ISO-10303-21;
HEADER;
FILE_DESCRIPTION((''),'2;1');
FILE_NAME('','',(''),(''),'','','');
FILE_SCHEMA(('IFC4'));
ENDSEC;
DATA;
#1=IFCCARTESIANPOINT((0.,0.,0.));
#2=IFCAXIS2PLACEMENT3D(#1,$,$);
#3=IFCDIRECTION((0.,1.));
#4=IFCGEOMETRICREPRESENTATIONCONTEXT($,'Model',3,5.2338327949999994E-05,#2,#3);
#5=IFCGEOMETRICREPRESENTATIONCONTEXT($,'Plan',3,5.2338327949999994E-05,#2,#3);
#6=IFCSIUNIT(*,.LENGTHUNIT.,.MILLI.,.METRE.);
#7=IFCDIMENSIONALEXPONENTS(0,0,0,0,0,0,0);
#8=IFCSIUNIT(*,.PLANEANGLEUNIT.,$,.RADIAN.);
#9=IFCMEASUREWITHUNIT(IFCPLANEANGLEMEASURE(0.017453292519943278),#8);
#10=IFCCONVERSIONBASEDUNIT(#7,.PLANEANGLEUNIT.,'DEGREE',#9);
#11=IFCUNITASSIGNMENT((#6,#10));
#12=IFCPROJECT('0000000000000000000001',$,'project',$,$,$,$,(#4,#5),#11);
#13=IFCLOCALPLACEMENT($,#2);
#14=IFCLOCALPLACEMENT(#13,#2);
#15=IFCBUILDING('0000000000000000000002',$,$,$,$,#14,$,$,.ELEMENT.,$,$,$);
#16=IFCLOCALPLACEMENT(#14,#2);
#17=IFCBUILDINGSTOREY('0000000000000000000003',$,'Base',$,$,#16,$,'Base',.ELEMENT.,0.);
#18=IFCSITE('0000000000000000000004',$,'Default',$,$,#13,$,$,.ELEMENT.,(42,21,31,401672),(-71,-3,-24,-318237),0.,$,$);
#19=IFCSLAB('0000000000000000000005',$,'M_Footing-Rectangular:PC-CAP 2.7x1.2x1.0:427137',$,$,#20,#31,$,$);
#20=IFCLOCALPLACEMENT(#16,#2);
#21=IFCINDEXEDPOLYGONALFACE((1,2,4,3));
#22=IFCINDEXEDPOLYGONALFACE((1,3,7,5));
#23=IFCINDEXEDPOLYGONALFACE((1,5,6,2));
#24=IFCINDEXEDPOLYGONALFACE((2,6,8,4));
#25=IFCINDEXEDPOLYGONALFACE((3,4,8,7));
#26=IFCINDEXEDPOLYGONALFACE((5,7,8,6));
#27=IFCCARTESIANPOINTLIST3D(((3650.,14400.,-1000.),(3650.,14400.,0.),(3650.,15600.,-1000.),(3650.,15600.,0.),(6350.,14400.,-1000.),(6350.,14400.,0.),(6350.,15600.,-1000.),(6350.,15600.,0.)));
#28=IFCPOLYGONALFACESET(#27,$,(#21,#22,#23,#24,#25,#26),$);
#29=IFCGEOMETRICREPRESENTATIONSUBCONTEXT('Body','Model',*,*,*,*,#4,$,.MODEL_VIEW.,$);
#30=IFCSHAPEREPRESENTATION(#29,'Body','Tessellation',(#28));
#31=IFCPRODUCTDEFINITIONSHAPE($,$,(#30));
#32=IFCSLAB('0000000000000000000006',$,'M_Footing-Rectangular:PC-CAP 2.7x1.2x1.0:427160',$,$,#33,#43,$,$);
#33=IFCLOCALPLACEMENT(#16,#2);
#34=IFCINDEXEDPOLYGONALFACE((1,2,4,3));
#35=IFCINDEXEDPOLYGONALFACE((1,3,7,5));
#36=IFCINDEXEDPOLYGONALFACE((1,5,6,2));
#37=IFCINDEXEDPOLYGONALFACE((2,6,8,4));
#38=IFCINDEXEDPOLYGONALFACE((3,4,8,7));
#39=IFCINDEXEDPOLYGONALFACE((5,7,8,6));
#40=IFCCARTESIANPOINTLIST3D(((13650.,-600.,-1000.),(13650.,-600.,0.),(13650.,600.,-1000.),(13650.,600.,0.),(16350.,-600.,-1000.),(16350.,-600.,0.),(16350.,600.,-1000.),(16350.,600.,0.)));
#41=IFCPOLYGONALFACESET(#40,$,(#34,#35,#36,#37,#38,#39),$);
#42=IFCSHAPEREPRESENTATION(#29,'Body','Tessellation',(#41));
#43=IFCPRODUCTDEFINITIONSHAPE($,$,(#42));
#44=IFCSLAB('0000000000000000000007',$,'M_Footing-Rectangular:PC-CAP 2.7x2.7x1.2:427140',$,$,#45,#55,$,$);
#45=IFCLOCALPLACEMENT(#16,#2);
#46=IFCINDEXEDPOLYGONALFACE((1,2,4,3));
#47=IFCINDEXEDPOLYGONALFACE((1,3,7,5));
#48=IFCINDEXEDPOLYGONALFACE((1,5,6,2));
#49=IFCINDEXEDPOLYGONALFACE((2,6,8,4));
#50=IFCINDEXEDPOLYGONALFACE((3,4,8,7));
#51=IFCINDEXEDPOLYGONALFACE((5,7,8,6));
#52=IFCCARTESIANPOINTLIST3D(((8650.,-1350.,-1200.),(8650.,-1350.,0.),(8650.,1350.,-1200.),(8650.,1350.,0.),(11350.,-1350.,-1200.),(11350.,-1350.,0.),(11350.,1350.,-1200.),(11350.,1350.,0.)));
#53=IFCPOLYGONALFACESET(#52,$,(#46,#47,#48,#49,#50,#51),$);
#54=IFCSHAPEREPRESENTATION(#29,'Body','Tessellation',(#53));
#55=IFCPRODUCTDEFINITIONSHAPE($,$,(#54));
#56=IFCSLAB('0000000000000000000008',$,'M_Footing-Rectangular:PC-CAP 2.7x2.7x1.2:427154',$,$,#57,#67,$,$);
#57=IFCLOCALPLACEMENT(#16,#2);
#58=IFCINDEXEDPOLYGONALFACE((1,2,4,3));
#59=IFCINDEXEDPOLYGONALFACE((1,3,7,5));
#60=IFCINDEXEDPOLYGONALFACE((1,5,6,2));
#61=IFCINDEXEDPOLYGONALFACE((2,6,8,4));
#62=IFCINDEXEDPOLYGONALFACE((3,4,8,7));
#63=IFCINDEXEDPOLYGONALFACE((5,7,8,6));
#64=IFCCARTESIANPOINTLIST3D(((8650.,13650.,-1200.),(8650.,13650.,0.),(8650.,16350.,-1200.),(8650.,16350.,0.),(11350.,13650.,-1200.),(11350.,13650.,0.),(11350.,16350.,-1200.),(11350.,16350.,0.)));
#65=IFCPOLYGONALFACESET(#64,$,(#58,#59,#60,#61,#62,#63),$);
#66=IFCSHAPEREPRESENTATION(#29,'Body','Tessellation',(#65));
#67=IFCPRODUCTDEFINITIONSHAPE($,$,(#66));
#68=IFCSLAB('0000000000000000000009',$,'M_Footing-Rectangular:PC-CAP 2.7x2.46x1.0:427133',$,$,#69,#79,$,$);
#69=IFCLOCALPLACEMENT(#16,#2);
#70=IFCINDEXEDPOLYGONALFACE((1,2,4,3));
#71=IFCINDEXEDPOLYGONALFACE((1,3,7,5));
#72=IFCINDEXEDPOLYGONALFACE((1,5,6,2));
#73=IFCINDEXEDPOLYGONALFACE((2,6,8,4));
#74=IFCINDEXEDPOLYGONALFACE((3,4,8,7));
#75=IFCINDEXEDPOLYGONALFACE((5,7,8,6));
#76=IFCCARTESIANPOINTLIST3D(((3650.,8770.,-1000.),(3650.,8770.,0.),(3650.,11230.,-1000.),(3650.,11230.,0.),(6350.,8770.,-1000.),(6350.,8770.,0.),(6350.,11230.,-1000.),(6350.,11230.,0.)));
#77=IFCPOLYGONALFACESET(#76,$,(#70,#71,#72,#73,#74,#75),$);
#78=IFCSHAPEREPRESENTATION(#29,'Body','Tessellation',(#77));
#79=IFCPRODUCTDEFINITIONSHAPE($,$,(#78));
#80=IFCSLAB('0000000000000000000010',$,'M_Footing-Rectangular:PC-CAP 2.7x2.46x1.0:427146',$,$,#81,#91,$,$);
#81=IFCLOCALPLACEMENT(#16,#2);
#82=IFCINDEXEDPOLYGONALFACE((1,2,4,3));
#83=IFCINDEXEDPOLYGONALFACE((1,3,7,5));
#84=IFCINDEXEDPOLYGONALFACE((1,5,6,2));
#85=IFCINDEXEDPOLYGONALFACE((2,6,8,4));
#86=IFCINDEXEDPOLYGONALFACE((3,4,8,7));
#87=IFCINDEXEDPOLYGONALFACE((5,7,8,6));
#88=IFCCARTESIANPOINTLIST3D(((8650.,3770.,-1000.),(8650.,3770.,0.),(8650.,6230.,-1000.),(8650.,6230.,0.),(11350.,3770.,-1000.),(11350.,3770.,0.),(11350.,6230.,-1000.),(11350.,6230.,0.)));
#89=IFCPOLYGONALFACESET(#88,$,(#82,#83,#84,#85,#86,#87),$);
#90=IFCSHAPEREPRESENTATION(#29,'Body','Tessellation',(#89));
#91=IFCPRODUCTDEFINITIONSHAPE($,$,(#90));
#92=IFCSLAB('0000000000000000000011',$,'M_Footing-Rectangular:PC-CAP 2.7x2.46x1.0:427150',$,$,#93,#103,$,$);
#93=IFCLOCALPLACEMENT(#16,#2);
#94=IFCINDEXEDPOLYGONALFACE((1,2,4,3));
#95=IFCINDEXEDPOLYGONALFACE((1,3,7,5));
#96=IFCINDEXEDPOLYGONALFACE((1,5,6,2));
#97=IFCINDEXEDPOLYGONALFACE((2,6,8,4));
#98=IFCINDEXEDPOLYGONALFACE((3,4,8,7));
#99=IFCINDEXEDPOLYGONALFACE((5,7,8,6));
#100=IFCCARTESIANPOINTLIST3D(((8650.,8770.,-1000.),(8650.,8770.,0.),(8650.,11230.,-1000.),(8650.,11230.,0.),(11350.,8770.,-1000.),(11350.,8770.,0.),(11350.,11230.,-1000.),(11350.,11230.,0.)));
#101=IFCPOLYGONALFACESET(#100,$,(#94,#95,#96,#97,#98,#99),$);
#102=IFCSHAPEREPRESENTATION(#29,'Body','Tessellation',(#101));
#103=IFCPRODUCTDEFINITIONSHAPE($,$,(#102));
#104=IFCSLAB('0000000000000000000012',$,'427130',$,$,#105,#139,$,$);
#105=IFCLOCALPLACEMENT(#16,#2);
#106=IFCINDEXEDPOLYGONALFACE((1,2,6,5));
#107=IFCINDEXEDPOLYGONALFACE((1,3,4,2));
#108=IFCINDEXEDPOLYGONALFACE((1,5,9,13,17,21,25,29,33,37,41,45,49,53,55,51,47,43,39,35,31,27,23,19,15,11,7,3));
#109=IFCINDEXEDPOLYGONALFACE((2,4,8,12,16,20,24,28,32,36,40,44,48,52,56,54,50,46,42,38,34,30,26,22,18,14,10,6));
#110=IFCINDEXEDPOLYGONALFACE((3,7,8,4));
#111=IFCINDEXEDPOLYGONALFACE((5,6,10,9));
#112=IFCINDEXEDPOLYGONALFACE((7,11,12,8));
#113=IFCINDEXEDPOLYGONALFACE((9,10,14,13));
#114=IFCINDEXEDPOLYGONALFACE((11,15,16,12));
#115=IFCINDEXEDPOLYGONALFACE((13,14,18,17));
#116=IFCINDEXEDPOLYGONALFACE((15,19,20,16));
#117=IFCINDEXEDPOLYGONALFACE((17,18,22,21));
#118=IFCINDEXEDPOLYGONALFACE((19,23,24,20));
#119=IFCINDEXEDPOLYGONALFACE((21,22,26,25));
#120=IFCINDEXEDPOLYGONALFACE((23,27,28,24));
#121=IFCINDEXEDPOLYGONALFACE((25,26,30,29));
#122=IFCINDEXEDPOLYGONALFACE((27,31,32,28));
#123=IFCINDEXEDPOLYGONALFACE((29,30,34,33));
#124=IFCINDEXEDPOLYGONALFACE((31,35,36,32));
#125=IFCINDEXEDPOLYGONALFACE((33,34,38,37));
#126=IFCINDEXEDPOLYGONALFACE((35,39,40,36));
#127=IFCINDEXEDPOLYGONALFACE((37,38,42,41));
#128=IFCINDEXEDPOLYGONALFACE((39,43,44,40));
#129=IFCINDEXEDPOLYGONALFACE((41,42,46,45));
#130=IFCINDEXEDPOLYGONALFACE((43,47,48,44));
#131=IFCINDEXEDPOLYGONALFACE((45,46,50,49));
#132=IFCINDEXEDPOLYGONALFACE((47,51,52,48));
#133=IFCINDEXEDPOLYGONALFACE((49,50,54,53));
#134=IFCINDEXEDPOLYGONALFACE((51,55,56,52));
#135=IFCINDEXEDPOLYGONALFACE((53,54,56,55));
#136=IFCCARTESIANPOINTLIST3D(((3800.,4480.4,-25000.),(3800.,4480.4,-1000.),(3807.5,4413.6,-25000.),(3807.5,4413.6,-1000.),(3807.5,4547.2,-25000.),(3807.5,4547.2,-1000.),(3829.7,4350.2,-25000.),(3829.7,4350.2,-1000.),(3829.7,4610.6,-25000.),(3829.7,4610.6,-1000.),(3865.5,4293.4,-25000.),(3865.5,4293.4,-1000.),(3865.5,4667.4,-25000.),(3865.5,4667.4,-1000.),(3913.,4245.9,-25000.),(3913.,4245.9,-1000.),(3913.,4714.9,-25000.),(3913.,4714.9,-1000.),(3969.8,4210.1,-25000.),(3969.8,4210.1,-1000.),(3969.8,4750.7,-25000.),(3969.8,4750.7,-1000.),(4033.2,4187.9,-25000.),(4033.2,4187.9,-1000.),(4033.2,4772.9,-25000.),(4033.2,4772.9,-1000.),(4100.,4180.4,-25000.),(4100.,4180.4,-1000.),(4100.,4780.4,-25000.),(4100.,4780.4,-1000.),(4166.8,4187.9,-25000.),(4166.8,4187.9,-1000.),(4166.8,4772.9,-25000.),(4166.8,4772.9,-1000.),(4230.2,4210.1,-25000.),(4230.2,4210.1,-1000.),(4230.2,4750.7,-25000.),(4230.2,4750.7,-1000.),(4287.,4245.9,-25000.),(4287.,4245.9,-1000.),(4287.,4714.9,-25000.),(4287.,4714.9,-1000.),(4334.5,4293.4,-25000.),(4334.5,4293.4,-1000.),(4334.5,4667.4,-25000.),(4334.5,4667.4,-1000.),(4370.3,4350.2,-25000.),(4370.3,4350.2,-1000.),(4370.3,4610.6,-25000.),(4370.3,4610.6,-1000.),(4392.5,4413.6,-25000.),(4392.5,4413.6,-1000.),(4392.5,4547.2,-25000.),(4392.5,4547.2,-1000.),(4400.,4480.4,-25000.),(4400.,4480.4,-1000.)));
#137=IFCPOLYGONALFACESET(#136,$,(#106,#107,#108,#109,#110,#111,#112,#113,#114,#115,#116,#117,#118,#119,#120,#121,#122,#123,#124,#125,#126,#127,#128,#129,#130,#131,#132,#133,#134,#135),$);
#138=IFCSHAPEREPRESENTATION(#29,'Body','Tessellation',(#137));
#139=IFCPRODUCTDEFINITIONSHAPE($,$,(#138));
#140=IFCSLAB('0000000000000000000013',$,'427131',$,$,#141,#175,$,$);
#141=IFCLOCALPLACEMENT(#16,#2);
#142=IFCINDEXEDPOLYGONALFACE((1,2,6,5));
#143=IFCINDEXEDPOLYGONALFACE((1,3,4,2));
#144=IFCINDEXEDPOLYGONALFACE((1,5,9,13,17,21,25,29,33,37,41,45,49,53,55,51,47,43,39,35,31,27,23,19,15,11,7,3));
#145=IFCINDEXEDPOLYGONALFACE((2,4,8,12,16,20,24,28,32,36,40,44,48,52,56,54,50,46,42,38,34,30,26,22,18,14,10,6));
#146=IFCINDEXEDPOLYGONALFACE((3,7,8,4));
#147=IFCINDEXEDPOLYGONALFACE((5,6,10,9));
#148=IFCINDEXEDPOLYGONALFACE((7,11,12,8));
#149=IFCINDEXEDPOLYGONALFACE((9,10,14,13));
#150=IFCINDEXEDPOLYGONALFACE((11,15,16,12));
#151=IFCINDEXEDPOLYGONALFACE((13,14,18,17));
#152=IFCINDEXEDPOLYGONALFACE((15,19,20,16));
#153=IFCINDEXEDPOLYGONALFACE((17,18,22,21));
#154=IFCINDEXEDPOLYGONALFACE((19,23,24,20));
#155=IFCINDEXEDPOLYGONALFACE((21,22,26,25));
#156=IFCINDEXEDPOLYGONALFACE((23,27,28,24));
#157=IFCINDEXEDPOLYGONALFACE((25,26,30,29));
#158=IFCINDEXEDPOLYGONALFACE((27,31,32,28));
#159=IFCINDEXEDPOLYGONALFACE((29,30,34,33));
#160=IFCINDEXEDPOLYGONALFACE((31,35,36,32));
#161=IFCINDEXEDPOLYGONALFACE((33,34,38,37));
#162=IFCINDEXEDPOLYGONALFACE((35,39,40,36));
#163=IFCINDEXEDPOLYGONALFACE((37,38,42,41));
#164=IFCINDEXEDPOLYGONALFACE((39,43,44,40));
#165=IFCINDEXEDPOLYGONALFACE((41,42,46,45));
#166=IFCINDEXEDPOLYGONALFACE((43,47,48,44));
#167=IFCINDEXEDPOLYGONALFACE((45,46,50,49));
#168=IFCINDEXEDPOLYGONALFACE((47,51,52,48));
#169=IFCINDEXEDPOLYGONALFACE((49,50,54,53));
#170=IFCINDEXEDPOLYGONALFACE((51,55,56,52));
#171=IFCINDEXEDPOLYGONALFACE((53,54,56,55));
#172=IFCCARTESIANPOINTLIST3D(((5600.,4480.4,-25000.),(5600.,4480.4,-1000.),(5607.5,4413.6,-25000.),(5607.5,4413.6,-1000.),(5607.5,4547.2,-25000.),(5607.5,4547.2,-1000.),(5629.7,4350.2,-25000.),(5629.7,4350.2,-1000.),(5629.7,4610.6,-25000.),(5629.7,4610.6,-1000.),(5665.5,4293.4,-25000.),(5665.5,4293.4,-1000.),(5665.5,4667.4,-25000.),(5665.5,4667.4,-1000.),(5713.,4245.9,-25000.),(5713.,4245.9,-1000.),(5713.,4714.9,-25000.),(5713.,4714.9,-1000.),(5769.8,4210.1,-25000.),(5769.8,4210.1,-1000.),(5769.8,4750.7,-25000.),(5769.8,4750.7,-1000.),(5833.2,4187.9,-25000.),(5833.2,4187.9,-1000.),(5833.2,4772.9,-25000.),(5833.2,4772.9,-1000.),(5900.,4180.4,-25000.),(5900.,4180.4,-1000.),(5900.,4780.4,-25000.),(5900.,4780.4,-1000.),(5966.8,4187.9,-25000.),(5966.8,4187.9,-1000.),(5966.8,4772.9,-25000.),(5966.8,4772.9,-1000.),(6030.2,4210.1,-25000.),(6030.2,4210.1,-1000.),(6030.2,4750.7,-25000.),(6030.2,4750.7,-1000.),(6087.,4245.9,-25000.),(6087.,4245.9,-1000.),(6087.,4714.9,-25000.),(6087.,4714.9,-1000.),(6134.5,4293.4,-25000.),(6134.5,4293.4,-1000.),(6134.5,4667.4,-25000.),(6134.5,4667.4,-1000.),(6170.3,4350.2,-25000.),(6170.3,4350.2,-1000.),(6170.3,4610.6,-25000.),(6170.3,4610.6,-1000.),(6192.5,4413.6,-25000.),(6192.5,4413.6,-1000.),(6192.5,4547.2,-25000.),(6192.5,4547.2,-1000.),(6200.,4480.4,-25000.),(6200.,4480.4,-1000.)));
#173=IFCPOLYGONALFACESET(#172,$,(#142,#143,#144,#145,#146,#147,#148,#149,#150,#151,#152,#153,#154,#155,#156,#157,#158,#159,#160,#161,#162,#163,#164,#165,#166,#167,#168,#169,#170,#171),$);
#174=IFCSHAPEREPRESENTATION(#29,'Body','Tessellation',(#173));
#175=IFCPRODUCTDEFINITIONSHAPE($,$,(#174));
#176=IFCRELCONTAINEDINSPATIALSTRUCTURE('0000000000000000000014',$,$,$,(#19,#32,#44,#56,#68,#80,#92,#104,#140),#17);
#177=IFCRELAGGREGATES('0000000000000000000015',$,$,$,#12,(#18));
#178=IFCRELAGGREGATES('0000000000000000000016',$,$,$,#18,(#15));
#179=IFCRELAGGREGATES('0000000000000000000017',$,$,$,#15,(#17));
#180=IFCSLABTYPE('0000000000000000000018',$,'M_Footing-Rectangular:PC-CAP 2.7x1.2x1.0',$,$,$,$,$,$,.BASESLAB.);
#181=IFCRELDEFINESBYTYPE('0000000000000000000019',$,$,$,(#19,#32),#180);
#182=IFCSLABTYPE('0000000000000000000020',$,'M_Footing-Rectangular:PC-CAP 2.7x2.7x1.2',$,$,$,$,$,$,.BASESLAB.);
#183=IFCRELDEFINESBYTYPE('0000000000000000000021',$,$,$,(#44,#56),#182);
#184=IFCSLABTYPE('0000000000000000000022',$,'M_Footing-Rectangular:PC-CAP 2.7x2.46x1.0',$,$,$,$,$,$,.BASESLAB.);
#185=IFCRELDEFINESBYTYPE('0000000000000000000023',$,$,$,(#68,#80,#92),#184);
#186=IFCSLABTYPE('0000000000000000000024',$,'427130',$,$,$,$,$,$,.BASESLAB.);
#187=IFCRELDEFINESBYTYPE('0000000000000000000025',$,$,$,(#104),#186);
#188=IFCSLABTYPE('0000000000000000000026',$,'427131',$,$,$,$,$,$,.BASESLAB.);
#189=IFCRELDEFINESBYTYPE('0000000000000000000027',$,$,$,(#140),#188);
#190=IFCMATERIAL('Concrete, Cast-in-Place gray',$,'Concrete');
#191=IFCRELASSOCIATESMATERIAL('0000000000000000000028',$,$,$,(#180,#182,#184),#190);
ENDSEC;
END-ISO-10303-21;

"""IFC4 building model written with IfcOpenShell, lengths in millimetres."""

from ifc_helpers import new_model, entity, si_unit, converted_unit, direction, frame, origin, place, context, subcontext, project, spatial, arc, indexed_curve, outline, extrude, material, type_object, element, save


model = new_model("IFC4")

# Units and contexts
model_context = context("Model", 3, precision=5.2338327949999994e-05, world=origin(), true_north=direction((0.0, 1.0)))
plan_context = context("Plan", 3, precision=5.2338327949999994e-05, world=origin(), true_north=direction((0.0, 1.0)))
body_context = subcontext(model_context, "Body", "Model", "MODEL_VIEW")
ifc_project = project(units=[si_unit("LENGTHUNIT", "METRE", prefix="MILLI"), converted_unit("PLANEANGLEUNIT", "DEGREE", entity("IfcPlaneAngleMeasure", 0.017453292519943278), si_unit("PLANEANGLEUNIT", "RADIAN"), dimensions=[0, 0, 0, 0, 0, 0, 0])], contexts=[model_context, plan_context])

# Site, building, storey
site_placement = place(None, origin())
site = spatial("IfcSite", under=ifc_project, at=site_placement, Name="Default", CompositionType="ELEMENT", RefLatitude=(42, 21, 31, 401672), RefLongitude=(-71, -3, -24, -318237), RefElevation=0.0)
building_placement = place(site_placement, origin())
building = spatial("IfcBuilding", under=site, at=building_placement, CompositionType="ELEMENT")
storey_placement = place(building_placement, origin())
storey = spatial("IfcBuildingStorey", under=building, at=storey_placement, Name="Base", LongName="Base", CompositionType="ELEMENT", Elevation=0.0)

# Slabs
ifc_material_1 = material(Name="Concrete, Cast-in-Place gray", Category="Concrete")
slab_type_1 = type_object("IfcSlabType", Name="M_Footing-Rectangular:PC-CAP 2.7x1.2x1.0", PredefinedType="BASESLAB", material=ifc_material_1)
slab_1_placement = place(storey_placement, origin())
element("IfcSlab", 1, at=slab_1_placement, inside=storey, type_object=slab_type_1, Name="M_Footing-Rectangular:PC-CAP 2.7x1.2x1.0:427137", context=body_context, shape_type="SweptSolid", body=[
    extrude(outline(indexed_curve([(-1350.0, -600.0), (1350.0, -600.0), (1350.0, 600.0), (-1350.0, 600.0), (-1350.0, -600.0)], self_intersect=False)), frame((5000.0, 15000.0, -1000.0), z_axis=(0.0, 0.0, 1.0), x_axis=(-1.0, 0.0, 0.0)), (0.0, 0.0, 1.0), 1000.0),
])
slab_2_placement = place(storey_placement, origin())
element("IfcSlab", 2, at=slab_2_placement, inside=storey, type_object=slab_type_1, Name="M_Footing-Rectangular:PC-CAP 2.7x1.2x1.0:427160", context=body_context, shape_type="SweptSolid", body=[
    extrude(outline(indexed_curve([(-1350.0, -600.0), (1350.0, -600.0), (1350.0, 600.0), (-1350.0, 600.0), (-1350.0, -600.0)], self_intersect=False)), frame((15000.0, 0.0, -1000.0), z_axis=(0.0, 0.0, 1.0), x_axis=(-1.0, 0.0, 0.0)), (0.0, 0.0, 1.0), 1000.0),
])
slab_type_2 = type_object("IfcSlabType", Name="M_Footing-Rectangular:PC-CAP 2.7x2.7x1.2", PredefinedType="BASESLAB", material=ifc_material_1)
slab_3_placement = place(storey_placement, origin())
element("IfcSlab", 3, at=slab_3_placement, inside=storey, type_object=slab_type_2, Name="M_Footing-Rectangular:PC-CAP 2.7x2.7x1.2:427140", context=body_context, shape_type="SweptSolid", body=[
    extrude(outline(indexed_curve([(-1350.0, -1350.0), (1350.0, -1350.0), (1350.0, 1350.0), (-1350.0, 1350.0), (-1350.0, -1350.0)], self_intersect=False)), frame((10000.0, 0.0, -1200.0), z_axis=(0.0, 0.0, 1.0), x_axis=(-1.0, 0.0, 0.0)), (0.0, 0.0, 1.0), 1200.0),
])
slab_4_placement = place(storey_placement, origin())
element("IfcSlab", 4, at=slab_4_placement, inside=storey, type_object=slab_type_2, Name="M_Footing-Rectangular:PC-CAP 2.7x2.7x1.2:427154", context=body_context, shape_type="SweptSolid", body=[
    extrude(outline(indexed_curve([(-1350.0, -1350.0), (1350.0, -1350.0), (1350.0, 1350.0), (-1350.0, 1350.0), (-1350.0, -1350.0)], self_intersect=False)), frame((10000.0, 15000.0, -1200.0), z_axis=(0.0, 0.0, 1.0), x_axis=(-1.0, 0.0, 0.0)), (0.0, 0.0, 1.0), 1200.0),
])
slab_type_3 = type_object("IfcSlabType", Name="M_Footing-Rectangular:PC-CAP 2.7x2.46x1.0", PredefinedType="BASESLAB", material=ifc_material_1)
slab_5_placement = place(storey_placement, origin())
element("IfcSlab", 5, at=slab_5_placement, inside=storey, type_object=slab_type_3, Name="M_Footing-Rectangular:PC-CAP 2.7x2.46x1.0:427133", context=body_context, shape_type="SweptSolid", body=[
    extrude(outline(indexed_curve([(-1350.0, -1230.0), (1350.0, -1230.0), (1350.0, 1230.0), (-1350.0, 1230.0), (-1350.0, -1230.0)], self_intersect=False)), frame((5000.0, 10000.0, -1000.0), z_axis=(0.0, 0.0, 1.0), x_axis=(-1.0, 0.0, 0.0)), (0.0, 0.0, 1.0), 1000.0),
])
slab_6_placement = place(storey_placement, origin())
element("IfcSlab", 6, at=slab_6_placement, inside=storey, type_object=slab_type_3, Name="M_Footing-Rectangular:PC-CAP 2.7x2.46x1.0:427146", context=body_context, shape_type="SweptSolid", body=[
    extrude(outline(indexed_curve([(-1350.0, -1230.0), (1350.0, -1230.0), (1350.0, 1230.0), (-1350.0, 1230.0), (-1350.0, -1230.0)], self_intersect=False)), frame((10000.0, 5000.0, -1000.0), z_axis=(0.0, 0.0, 1.0), x_axis=(-1.0, 0.0, 0.0)), (0.0, 0.0, 1.0), 1000.0),
])
slab_7_placement = place(storey_placement, origin())
element("IfcSlab", 7, at=slab_7_placement, inside=storey, type_object=slab_type_3, Name="M_Footing-Rectangular:PC-CAP 2.7x2.46x1.0:427150", context=body_context, shape_type="SweptSolid", body=[
    extrude(outline(indexed_curve([(-1350.0, -1230.0), (1350.0, -1230.0), (1350.0, 1230.0), (-1350.0, 1230.0), (-1350.0, -1230.0)], self_intersect=False)), frame((10000.0, 10000.0, -1000.0), z_axis=(0.0, 0.0, 1.0), x_axis=(-1.0, 0.0, 0.0)), (0.0, 0.0, 1.0), 1000.0),
])
slab_type_4 = type_object("IfcSlabType", Name="427130", PredefinedType="BASESLAB")
slab_8_placement = place(storey_placement, origin())
element("IfcSlab", 8, at=slab_8_placement, inside=storey, type_object=slab_type_4, Name="427130", context=body_context, shape_type="SweptSolid", body=[
    extrude(outline(indexed_curve([(300.0, 0.0), (0.0, 300.0), (-300.0, 0.0), (0.0, -300.0)], segments=[arc(1, 2, 3), arc(3, 4, 1)], self_intersect=False)), frame((4100.0, 4480.4, -25000.0)), (0.0, 0.0, 1.0), 24000.0),
])
slab_type_5 = type_object("IfcSlabType", Name="427131", PredefinedType="BASESLAB")
slab_9_placement = place(storey_placement, origin())
element("IfcSlab", 9, at=slab_9_placement, inside=storey, type_object=slab_type_5, Name="427131", context=body_context, shape_type="SweptSolid", body=[
    extrude(outline(indexed_curve([(300.0, 0.0), (0.0, 300.0), (-300.0, 0.0), (0.0, -300.0)], segments=[arc(1, 2, 3), arc(3, 4, 1)], self_intersect=False)), frame((5900.0, 4480.4, -25000.0)), (0.0, 0.0, 1.0), 24000.0),
])

save(model, "model.ifc")
